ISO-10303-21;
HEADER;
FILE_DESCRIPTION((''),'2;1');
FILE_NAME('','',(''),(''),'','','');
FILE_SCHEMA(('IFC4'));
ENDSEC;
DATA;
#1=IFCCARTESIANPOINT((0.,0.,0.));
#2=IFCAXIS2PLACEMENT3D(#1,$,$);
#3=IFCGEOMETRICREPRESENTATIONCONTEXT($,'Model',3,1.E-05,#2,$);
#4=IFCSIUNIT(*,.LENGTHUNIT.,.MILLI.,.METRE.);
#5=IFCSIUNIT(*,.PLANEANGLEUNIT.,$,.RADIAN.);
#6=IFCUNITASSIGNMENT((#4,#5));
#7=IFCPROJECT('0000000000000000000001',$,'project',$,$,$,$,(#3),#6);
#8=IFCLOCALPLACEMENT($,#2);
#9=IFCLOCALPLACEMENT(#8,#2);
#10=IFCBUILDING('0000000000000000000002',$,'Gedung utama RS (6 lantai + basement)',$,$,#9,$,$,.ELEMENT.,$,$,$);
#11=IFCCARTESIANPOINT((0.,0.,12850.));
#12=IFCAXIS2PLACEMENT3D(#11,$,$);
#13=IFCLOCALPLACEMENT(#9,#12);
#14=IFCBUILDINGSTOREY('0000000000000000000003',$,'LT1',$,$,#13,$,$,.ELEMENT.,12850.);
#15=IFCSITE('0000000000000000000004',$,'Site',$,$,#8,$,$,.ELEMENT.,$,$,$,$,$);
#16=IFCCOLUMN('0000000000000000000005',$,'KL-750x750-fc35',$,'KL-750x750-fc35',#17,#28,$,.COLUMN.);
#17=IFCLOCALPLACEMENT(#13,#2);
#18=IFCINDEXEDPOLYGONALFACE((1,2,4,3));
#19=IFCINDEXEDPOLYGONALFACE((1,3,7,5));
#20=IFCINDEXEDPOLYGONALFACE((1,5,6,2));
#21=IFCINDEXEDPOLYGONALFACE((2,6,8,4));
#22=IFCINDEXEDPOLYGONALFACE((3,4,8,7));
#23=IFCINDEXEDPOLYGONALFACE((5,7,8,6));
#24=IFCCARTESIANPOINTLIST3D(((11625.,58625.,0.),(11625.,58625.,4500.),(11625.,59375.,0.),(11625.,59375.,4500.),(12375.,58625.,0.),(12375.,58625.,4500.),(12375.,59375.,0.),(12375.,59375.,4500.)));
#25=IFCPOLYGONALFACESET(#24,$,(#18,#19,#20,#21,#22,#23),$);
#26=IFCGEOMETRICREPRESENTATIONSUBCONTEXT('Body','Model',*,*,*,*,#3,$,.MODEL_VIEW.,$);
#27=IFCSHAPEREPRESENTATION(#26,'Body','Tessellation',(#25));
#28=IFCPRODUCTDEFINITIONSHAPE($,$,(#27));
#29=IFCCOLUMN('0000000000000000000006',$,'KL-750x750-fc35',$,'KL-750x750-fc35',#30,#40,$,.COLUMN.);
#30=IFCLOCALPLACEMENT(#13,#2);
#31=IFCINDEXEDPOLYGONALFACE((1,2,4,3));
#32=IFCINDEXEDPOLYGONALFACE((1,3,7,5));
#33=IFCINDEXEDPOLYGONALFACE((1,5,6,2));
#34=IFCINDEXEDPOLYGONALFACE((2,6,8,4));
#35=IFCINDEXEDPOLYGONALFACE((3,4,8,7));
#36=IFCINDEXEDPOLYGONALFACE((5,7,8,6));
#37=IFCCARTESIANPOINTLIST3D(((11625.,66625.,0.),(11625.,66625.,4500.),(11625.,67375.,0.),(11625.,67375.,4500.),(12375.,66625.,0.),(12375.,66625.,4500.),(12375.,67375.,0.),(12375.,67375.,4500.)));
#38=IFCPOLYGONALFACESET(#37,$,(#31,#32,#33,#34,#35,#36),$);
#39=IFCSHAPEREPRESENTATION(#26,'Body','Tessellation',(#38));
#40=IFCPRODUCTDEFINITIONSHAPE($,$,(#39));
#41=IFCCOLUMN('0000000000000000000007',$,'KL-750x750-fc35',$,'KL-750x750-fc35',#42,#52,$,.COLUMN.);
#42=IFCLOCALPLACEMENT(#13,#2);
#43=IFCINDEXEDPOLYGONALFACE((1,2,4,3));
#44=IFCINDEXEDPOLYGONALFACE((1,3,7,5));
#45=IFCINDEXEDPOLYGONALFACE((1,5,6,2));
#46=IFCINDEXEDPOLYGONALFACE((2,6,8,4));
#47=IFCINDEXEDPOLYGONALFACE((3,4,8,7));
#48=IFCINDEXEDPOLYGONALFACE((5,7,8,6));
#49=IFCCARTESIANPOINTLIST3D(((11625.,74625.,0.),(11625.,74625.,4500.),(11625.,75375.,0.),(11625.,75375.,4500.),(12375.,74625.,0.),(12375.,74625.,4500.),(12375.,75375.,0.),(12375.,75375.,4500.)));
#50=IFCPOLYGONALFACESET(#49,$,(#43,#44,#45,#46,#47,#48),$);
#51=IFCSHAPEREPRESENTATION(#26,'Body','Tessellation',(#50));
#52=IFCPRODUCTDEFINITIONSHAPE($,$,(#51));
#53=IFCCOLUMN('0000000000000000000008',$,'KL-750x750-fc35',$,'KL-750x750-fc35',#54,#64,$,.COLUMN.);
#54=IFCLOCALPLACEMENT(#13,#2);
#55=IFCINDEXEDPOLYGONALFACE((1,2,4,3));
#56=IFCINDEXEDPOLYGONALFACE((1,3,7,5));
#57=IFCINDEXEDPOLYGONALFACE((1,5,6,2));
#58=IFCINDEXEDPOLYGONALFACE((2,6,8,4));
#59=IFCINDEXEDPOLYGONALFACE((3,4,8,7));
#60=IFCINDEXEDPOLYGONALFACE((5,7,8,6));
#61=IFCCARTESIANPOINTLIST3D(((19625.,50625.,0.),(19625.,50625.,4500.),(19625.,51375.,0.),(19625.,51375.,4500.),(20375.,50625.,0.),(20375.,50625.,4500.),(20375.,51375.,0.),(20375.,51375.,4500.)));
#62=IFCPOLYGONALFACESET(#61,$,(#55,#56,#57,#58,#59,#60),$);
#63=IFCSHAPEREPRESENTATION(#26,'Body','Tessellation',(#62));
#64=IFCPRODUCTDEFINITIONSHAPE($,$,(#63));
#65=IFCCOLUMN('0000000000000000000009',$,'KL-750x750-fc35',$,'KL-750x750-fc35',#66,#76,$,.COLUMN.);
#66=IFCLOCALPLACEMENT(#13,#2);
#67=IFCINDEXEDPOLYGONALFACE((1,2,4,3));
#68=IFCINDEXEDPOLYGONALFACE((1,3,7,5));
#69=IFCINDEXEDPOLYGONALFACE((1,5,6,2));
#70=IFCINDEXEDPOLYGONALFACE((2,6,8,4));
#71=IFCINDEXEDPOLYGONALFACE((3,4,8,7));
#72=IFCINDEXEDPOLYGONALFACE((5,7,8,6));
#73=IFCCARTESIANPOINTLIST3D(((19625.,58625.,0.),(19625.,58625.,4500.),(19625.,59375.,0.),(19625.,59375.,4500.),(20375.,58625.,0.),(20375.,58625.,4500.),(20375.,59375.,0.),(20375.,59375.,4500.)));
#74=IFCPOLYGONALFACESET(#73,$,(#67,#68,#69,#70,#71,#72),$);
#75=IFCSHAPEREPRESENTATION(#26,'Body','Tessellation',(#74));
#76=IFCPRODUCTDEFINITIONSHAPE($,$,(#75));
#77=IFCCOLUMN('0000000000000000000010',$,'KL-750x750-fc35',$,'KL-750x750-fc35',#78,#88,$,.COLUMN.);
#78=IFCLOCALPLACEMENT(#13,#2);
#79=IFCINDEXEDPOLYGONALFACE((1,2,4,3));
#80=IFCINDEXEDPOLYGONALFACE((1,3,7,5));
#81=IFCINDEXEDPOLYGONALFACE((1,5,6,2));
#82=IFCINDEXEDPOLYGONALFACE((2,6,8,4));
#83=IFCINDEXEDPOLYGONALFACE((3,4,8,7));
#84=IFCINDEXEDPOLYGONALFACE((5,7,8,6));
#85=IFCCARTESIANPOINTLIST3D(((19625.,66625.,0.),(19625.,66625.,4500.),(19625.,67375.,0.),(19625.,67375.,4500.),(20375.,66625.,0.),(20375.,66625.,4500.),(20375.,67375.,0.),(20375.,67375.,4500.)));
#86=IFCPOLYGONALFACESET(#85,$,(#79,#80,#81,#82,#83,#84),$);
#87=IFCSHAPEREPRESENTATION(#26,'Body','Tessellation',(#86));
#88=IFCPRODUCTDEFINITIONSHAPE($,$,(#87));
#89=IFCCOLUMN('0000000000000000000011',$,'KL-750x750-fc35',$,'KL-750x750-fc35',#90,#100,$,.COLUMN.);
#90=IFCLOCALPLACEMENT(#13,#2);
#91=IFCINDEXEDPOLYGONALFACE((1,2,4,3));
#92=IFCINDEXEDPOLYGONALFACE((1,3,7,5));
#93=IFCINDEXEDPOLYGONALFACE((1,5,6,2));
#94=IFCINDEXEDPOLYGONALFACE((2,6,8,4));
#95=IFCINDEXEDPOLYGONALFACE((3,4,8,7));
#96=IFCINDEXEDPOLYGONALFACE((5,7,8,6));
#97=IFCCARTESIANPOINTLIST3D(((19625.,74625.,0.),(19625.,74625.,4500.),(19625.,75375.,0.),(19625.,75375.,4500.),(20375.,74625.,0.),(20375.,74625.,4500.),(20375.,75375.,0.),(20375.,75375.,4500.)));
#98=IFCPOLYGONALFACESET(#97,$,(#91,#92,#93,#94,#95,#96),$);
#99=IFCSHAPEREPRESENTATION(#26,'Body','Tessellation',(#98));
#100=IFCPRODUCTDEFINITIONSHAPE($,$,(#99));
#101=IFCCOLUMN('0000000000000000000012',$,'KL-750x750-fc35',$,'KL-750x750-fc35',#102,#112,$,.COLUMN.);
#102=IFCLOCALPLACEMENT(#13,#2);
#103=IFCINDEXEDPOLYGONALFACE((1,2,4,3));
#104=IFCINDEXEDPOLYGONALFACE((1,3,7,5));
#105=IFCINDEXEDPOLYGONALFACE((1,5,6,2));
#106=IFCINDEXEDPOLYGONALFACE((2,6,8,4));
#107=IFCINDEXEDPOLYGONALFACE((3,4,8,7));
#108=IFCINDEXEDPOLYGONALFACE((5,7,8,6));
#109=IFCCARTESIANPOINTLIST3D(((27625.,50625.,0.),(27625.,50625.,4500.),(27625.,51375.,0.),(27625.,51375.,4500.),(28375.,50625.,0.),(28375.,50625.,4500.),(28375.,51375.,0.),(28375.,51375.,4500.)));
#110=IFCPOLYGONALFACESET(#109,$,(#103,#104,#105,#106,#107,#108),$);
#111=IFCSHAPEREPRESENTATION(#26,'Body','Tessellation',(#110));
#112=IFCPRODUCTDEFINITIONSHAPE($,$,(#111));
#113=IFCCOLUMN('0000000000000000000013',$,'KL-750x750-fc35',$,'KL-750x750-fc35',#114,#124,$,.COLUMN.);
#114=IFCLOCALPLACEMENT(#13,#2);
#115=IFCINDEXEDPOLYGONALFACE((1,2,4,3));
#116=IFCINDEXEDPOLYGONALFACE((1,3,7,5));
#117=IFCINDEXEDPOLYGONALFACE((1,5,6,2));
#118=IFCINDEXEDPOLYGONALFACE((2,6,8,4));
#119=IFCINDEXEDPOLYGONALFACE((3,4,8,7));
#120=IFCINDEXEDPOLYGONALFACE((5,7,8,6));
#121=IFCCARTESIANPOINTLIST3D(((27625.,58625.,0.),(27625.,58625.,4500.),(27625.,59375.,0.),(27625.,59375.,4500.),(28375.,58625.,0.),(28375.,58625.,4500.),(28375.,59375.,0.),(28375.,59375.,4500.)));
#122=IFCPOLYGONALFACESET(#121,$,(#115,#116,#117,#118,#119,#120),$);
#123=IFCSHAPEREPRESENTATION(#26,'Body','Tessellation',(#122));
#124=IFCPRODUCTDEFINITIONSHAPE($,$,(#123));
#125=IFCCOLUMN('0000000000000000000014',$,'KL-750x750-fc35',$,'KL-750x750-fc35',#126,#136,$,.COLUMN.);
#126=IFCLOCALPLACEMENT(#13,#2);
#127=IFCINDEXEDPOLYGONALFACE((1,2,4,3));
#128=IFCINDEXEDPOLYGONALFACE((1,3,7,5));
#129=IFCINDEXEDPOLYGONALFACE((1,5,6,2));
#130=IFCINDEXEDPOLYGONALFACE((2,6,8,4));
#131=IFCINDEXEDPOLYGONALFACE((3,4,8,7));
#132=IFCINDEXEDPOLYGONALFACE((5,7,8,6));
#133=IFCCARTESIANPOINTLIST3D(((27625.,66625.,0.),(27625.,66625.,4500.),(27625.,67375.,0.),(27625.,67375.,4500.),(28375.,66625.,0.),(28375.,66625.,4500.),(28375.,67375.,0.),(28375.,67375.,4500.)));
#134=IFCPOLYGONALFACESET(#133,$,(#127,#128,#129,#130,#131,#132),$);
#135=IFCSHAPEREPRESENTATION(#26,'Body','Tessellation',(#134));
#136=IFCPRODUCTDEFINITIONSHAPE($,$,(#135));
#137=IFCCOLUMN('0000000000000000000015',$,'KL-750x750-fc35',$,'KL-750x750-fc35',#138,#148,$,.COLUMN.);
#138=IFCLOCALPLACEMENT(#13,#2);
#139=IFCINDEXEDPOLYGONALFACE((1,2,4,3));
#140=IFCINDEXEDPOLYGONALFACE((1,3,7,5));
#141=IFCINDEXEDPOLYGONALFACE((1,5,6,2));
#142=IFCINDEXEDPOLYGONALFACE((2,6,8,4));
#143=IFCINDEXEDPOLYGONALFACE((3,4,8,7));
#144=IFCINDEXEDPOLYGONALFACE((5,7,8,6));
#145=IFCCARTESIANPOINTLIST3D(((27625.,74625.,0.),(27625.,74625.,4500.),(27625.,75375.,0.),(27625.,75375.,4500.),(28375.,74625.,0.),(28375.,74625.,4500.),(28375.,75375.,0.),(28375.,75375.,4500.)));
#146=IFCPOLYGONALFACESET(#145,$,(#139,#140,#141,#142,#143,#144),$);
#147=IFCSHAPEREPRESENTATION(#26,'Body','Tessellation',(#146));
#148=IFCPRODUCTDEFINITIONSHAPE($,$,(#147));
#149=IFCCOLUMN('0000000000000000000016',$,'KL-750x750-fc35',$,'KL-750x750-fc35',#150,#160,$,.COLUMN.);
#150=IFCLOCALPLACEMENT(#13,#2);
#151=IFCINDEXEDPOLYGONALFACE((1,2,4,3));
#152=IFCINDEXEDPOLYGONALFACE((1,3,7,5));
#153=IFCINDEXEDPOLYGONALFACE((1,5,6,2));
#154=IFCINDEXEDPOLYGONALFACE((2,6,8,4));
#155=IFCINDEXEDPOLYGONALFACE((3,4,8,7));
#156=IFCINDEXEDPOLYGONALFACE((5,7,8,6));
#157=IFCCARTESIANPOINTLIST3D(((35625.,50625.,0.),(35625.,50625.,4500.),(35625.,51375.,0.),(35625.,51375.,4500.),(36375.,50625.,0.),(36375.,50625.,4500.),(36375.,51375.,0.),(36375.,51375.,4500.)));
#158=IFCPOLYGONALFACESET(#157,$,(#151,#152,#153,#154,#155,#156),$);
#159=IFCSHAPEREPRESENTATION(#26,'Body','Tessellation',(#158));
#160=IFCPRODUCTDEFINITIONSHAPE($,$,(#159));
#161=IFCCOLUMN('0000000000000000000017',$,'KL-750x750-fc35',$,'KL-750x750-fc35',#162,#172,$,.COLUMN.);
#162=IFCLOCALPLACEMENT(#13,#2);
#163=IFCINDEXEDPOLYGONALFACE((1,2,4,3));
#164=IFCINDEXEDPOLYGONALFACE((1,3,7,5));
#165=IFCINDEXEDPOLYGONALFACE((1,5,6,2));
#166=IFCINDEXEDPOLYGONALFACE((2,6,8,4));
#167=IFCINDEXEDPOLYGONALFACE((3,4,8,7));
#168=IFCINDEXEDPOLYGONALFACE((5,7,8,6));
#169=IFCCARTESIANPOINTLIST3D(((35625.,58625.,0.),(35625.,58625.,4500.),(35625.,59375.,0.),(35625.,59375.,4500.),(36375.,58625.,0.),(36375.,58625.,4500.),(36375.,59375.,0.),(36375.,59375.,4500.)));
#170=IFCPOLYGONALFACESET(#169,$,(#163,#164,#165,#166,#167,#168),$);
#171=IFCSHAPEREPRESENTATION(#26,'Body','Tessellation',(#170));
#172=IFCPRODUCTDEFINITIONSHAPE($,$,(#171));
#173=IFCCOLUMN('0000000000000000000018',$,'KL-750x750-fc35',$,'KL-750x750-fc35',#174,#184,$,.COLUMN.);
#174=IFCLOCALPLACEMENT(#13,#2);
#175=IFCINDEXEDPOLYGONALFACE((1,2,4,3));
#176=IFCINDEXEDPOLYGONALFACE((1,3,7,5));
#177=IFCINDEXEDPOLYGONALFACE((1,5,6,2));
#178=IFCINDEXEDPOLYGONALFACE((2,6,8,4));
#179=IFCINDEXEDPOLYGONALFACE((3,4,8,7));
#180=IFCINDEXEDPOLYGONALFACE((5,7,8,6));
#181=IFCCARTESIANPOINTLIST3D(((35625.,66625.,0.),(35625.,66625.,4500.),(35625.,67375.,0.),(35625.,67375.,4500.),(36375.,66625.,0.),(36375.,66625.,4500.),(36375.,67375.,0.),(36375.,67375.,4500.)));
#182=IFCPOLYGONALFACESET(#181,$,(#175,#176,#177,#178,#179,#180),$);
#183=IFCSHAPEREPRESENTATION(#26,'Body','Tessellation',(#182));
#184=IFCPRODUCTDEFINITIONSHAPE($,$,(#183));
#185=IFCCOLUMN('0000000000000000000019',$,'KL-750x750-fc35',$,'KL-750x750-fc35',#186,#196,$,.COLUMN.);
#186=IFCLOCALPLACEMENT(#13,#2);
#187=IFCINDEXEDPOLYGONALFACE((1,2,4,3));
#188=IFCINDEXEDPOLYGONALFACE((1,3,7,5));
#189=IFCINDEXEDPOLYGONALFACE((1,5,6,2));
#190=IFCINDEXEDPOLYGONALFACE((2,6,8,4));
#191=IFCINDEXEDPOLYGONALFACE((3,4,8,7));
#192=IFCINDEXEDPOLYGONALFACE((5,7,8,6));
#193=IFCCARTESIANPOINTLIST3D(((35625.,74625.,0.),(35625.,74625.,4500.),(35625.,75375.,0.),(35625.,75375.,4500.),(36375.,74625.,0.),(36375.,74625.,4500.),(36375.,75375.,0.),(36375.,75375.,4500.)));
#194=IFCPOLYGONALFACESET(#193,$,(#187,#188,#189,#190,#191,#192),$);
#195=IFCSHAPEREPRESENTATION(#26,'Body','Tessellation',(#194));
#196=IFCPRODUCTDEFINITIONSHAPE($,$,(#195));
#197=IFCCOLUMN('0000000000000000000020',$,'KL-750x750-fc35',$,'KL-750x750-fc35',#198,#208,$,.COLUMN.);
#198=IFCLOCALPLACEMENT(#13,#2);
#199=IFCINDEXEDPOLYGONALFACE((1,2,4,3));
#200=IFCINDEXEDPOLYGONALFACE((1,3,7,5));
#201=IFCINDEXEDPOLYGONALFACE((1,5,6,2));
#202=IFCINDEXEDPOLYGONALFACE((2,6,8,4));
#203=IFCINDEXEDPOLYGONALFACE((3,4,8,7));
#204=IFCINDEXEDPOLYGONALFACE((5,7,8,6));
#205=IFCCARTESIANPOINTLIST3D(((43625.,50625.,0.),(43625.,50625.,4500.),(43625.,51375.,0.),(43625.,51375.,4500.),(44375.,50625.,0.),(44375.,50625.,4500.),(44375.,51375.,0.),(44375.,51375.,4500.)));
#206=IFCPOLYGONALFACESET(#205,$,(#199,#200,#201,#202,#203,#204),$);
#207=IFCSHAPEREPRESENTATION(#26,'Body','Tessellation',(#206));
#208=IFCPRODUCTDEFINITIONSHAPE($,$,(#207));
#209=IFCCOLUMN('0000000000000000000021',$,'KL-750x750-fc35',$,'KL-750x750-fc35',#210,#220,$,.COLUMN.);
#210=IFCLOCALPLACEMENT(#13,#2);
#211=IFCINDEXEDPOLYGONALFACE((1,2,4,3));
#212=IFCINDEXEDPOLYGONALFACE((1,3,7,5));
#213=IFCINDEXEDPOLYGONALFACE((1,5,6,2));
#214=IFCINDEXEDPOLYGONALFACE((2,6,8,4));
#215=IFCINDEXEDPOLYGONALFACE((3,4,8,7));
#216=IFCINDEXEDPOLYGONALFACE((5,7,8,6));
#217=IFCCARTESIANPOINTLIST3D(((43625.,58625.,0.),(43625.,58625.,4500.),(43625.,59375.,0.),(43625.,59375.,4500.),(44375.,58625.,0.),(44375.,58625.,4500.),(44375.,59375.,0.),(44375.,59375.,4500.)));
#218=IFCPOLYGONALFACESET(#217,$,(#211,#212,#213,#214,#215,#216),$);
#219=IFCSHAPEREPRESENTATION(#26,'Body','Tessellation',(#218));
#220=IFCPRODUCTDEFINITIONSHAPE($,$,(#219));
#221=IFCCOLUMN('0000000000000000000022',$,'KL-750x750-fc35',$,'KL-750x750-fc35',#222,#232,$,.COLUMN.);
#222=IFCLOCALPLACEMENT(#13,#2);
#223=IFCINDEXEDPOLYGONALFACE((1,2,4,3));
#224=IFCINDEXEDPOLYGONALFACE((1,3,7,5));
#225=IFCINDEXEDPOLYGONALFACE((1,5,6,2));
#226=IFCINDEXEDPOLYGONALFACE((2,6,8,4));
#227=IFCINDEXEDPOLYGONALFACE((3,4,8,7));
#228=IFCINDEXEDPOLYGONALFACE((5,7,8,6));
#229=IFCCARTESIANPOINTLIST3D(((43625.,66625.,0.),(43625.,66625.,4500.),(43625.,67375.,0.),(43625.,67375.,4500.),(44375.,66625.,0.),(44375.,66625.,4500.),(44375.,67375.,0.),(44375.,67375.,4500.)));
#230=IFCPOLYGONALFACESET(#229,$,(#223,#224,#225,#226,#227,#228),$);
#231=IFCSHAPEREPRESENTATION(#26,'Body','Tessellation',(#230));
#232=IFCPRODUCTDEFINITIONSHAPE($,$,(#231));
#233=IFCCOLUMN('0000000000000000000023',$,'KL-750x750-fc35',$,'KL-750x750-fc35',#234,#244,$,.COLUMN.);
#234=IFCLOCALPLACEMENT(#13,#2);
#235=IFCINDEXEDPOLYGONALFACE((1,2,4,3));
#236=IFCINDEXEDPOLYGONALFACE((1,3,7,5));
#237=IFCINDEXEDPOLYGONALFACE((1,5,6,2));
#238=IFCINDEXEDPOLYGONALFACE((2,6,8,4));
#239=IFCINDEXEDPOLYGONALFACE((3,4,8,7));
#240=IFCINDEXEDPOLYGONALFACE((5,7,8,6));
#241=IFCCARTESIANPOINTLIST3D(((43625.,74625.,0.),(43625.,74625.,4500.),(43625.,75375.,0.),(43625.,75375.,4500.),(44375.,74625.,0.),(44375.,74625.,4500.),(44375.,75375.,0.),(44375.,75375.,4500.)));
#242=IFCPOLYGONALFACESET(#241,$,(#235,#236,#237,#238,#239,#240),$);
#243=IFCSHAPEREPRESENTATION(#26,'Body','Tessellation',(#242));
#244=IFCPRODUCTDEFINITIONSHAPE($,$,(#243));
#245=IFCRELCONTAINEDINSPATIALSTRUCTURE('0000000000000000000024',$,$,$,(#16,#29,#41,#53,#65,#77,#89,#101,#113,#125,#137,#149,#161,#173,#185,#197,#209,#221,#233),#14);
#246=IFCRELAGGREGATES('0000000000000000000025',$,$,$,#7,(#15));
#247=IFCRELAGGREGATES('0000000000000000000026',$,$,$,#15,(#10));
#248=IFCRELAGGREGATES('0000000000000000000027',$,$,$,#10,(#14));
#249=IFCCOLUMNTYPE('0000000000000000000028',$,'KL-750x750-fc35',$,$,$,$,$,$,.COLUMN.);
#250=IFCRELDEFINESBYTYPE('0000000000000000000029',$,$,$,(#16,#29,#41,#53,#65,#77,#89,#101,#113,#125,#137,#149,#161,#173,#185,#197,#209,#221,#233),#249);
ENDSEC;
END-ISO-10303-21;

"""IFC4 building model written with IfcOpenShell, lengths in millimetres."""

from ifc_helpers import new_model, si_unit, frame, origin, origin_2d, place, context, subcontext, project, spatial, rectangle, extrude, material_profile, profile_set, profile_usage, type_object, element, save


model = new_model("IFC4")

# Units and contexts
model_context = context("Model", 3, precision=1e-05, world=origin())
body_context = subcontext(model_context, "Body", "Model", "MODEL_VIEW")
ifc_project = project(units=[si_unit("LENGTHUNIT", "METRE", prefix="MILLI"), si_unit("PLANEANGLEUNIT", "RADIAN")], contexts=[model_context])

# Site, building, storey
site_placement = place(None, origin())
site = spatial("IfcSite", under=ifc_project, at=site_placement, Name="Site", CompositionType="ELEMENT")
building_placement = place(site_placement, origin())
building = spatial("IfcBuilding", under=site, at=building_placement, Name="Gedung utama RS (6 lantai + basement)", CompositionType="ELEMENT")
storey_placement = place(building_placement, frame((0.0, 0.0, 12850.0)))
storey = spatial("IfcBuildingStorey", under=building, at=storey_placement, Name="LT1", CompositionType="ELEMENT", Elevation=12850.0)

# Columns
ifc_material_profile = material_profile(None, rectangle(XDim=750.0, YDim=750.0, at=origin_2d()), Name="KL-750x750-fc35")
ifc_profile_set = profile_set([ifc_material_profile], Name="KL-750x750-fc35")
ifc_profile_usage = profile_usage(ifc_profile_set, cardinal=5)
column_type = type_object("IfcColumnType", Name="KL-750x750-fc35", PredefinedType="COLUMN", material=ifc_profile_set)
for number, where, z_axis, x_axis, name in (
    (1, (12000.0, 59000.0, 0.0), (0.0, 0.0, 1.0), (1.0, 0.0, 0.0), "KL-750x750-fc35"),
    (2, (12000.0, 67000.0, 0.0), (0.0, 0.0, 1.0), (1.0, 0.0, 0.0), "KL-750x750-fc35"),
    (3, (12000.0, 75000.0, 0.0), (0.0, 0.0, 1.0), (1.0, 0.0, 0.0), "KL-750x750-fc35"),
    (4, (20000.0, 51000.0, 0.0), (0.0, 0.0, 1.0), (1.0, 0.0, 0.0), "KL-750x750-fc35"),
    (5, (20000.0, 59000.0, 0.0), (0.0, 0.0, 1.0), (1.0, 0.0, 0.0), "KL-750x750-fc35"),
    (6, (20000.0, 67000.0, 0.0), (0.0, 0.0, 1.0), (1.0, 0.0, 0.0), "KL-750x750-fc35"),
    (7, (20000.0, 75000.0, 0.0), (0.0, 0.0, 1.0), (1.0, 0.0, 0.0), "KL-750x750-fc35"),
    (8, (28000.0, 51000.0, 0.0), (0.0, 0.0, 1.0), (1.0, 0.0, 0.0), "KL-750x750-fc35"),
    (9, (28000.0, 59000.0, 0.0), (0.0, 0.0, 1.0), (1.0, 0.0, 0.0), "KL-750x750-fc35"),
    (10, (28000.0, 67000.0, 0.0), (0.0, 0.0, 1.0), (1.0, 0.0, 0.0), "KL-750x750-fc35"),
    (11, (28000.0, 75000.0, 0.0), (0.0, 0.0, 1.0), (1.0, 0.0, 0.0), "KL-750x750-fc35"),
    (12, (36000.0, 51000.0, 0.0), (0.0, 0.0, 1.0), (1.0, 0.0, 0.0), "KL-750x750-fc35"),
    (13, (36000.0, 59000.0, 0.0), (0.0, 0.0, 1.0), (1.0, 0.0, 0.0), "KL-750x750-fc35"),
    (14, (36000.0, 67000.0, 0.0), (0.0, 0.0, 1.0), (1.0, 0.0, 0.0), "KL-750x750-fc35"),
    (15, (36000.0, 75000.0, 0.0), (0.0, 0.0, 1.0), (1.0, 0.0, 0.0), "KL-750x750-fc35"),
    (16, (44000.0, 51000.0, 0.0), (0.0, 0.0, 1.0), (1.0, 0.0, 0.0), "KL-750x750-fc35"),
    (17, (44000.0, 59000.0, 0.0), (0.0, 0.0, 1.0), (1.0, 0.0, 0.0), "KL-750x750-fc35"),
    (18, (44000.0, 67000.0, 0.0), (0.0, 0.0, 1.0), (1.0, 0.0, 0.0), "KL-750x750-fc35"),
    (19, (44000.0, 75000.0, 0.0), (0.0, 0.0, 1.0), (1.0, 0.0, 0.0), "KL-750x750-fc35"),
):
    element("IfcColumn", number, at=place(storey_placement, frame(where, z_axis=z_axis, x_axis=x_axis)), inside=storey, type_object=column_type, material=ifc_profile_usage, Name=name, ObjectType="KL-750x750-fc35", PredefinedType="COLUMN", context=body_context, shape_type="SweptSolid", body=[
        extrude(rectangle(XDim=750.0, YDim=750.0, at=origin_2d()), origin(), (0.0, 0.0, 1.0), 4500.0),
    ])

save(model, "model.ifc")
